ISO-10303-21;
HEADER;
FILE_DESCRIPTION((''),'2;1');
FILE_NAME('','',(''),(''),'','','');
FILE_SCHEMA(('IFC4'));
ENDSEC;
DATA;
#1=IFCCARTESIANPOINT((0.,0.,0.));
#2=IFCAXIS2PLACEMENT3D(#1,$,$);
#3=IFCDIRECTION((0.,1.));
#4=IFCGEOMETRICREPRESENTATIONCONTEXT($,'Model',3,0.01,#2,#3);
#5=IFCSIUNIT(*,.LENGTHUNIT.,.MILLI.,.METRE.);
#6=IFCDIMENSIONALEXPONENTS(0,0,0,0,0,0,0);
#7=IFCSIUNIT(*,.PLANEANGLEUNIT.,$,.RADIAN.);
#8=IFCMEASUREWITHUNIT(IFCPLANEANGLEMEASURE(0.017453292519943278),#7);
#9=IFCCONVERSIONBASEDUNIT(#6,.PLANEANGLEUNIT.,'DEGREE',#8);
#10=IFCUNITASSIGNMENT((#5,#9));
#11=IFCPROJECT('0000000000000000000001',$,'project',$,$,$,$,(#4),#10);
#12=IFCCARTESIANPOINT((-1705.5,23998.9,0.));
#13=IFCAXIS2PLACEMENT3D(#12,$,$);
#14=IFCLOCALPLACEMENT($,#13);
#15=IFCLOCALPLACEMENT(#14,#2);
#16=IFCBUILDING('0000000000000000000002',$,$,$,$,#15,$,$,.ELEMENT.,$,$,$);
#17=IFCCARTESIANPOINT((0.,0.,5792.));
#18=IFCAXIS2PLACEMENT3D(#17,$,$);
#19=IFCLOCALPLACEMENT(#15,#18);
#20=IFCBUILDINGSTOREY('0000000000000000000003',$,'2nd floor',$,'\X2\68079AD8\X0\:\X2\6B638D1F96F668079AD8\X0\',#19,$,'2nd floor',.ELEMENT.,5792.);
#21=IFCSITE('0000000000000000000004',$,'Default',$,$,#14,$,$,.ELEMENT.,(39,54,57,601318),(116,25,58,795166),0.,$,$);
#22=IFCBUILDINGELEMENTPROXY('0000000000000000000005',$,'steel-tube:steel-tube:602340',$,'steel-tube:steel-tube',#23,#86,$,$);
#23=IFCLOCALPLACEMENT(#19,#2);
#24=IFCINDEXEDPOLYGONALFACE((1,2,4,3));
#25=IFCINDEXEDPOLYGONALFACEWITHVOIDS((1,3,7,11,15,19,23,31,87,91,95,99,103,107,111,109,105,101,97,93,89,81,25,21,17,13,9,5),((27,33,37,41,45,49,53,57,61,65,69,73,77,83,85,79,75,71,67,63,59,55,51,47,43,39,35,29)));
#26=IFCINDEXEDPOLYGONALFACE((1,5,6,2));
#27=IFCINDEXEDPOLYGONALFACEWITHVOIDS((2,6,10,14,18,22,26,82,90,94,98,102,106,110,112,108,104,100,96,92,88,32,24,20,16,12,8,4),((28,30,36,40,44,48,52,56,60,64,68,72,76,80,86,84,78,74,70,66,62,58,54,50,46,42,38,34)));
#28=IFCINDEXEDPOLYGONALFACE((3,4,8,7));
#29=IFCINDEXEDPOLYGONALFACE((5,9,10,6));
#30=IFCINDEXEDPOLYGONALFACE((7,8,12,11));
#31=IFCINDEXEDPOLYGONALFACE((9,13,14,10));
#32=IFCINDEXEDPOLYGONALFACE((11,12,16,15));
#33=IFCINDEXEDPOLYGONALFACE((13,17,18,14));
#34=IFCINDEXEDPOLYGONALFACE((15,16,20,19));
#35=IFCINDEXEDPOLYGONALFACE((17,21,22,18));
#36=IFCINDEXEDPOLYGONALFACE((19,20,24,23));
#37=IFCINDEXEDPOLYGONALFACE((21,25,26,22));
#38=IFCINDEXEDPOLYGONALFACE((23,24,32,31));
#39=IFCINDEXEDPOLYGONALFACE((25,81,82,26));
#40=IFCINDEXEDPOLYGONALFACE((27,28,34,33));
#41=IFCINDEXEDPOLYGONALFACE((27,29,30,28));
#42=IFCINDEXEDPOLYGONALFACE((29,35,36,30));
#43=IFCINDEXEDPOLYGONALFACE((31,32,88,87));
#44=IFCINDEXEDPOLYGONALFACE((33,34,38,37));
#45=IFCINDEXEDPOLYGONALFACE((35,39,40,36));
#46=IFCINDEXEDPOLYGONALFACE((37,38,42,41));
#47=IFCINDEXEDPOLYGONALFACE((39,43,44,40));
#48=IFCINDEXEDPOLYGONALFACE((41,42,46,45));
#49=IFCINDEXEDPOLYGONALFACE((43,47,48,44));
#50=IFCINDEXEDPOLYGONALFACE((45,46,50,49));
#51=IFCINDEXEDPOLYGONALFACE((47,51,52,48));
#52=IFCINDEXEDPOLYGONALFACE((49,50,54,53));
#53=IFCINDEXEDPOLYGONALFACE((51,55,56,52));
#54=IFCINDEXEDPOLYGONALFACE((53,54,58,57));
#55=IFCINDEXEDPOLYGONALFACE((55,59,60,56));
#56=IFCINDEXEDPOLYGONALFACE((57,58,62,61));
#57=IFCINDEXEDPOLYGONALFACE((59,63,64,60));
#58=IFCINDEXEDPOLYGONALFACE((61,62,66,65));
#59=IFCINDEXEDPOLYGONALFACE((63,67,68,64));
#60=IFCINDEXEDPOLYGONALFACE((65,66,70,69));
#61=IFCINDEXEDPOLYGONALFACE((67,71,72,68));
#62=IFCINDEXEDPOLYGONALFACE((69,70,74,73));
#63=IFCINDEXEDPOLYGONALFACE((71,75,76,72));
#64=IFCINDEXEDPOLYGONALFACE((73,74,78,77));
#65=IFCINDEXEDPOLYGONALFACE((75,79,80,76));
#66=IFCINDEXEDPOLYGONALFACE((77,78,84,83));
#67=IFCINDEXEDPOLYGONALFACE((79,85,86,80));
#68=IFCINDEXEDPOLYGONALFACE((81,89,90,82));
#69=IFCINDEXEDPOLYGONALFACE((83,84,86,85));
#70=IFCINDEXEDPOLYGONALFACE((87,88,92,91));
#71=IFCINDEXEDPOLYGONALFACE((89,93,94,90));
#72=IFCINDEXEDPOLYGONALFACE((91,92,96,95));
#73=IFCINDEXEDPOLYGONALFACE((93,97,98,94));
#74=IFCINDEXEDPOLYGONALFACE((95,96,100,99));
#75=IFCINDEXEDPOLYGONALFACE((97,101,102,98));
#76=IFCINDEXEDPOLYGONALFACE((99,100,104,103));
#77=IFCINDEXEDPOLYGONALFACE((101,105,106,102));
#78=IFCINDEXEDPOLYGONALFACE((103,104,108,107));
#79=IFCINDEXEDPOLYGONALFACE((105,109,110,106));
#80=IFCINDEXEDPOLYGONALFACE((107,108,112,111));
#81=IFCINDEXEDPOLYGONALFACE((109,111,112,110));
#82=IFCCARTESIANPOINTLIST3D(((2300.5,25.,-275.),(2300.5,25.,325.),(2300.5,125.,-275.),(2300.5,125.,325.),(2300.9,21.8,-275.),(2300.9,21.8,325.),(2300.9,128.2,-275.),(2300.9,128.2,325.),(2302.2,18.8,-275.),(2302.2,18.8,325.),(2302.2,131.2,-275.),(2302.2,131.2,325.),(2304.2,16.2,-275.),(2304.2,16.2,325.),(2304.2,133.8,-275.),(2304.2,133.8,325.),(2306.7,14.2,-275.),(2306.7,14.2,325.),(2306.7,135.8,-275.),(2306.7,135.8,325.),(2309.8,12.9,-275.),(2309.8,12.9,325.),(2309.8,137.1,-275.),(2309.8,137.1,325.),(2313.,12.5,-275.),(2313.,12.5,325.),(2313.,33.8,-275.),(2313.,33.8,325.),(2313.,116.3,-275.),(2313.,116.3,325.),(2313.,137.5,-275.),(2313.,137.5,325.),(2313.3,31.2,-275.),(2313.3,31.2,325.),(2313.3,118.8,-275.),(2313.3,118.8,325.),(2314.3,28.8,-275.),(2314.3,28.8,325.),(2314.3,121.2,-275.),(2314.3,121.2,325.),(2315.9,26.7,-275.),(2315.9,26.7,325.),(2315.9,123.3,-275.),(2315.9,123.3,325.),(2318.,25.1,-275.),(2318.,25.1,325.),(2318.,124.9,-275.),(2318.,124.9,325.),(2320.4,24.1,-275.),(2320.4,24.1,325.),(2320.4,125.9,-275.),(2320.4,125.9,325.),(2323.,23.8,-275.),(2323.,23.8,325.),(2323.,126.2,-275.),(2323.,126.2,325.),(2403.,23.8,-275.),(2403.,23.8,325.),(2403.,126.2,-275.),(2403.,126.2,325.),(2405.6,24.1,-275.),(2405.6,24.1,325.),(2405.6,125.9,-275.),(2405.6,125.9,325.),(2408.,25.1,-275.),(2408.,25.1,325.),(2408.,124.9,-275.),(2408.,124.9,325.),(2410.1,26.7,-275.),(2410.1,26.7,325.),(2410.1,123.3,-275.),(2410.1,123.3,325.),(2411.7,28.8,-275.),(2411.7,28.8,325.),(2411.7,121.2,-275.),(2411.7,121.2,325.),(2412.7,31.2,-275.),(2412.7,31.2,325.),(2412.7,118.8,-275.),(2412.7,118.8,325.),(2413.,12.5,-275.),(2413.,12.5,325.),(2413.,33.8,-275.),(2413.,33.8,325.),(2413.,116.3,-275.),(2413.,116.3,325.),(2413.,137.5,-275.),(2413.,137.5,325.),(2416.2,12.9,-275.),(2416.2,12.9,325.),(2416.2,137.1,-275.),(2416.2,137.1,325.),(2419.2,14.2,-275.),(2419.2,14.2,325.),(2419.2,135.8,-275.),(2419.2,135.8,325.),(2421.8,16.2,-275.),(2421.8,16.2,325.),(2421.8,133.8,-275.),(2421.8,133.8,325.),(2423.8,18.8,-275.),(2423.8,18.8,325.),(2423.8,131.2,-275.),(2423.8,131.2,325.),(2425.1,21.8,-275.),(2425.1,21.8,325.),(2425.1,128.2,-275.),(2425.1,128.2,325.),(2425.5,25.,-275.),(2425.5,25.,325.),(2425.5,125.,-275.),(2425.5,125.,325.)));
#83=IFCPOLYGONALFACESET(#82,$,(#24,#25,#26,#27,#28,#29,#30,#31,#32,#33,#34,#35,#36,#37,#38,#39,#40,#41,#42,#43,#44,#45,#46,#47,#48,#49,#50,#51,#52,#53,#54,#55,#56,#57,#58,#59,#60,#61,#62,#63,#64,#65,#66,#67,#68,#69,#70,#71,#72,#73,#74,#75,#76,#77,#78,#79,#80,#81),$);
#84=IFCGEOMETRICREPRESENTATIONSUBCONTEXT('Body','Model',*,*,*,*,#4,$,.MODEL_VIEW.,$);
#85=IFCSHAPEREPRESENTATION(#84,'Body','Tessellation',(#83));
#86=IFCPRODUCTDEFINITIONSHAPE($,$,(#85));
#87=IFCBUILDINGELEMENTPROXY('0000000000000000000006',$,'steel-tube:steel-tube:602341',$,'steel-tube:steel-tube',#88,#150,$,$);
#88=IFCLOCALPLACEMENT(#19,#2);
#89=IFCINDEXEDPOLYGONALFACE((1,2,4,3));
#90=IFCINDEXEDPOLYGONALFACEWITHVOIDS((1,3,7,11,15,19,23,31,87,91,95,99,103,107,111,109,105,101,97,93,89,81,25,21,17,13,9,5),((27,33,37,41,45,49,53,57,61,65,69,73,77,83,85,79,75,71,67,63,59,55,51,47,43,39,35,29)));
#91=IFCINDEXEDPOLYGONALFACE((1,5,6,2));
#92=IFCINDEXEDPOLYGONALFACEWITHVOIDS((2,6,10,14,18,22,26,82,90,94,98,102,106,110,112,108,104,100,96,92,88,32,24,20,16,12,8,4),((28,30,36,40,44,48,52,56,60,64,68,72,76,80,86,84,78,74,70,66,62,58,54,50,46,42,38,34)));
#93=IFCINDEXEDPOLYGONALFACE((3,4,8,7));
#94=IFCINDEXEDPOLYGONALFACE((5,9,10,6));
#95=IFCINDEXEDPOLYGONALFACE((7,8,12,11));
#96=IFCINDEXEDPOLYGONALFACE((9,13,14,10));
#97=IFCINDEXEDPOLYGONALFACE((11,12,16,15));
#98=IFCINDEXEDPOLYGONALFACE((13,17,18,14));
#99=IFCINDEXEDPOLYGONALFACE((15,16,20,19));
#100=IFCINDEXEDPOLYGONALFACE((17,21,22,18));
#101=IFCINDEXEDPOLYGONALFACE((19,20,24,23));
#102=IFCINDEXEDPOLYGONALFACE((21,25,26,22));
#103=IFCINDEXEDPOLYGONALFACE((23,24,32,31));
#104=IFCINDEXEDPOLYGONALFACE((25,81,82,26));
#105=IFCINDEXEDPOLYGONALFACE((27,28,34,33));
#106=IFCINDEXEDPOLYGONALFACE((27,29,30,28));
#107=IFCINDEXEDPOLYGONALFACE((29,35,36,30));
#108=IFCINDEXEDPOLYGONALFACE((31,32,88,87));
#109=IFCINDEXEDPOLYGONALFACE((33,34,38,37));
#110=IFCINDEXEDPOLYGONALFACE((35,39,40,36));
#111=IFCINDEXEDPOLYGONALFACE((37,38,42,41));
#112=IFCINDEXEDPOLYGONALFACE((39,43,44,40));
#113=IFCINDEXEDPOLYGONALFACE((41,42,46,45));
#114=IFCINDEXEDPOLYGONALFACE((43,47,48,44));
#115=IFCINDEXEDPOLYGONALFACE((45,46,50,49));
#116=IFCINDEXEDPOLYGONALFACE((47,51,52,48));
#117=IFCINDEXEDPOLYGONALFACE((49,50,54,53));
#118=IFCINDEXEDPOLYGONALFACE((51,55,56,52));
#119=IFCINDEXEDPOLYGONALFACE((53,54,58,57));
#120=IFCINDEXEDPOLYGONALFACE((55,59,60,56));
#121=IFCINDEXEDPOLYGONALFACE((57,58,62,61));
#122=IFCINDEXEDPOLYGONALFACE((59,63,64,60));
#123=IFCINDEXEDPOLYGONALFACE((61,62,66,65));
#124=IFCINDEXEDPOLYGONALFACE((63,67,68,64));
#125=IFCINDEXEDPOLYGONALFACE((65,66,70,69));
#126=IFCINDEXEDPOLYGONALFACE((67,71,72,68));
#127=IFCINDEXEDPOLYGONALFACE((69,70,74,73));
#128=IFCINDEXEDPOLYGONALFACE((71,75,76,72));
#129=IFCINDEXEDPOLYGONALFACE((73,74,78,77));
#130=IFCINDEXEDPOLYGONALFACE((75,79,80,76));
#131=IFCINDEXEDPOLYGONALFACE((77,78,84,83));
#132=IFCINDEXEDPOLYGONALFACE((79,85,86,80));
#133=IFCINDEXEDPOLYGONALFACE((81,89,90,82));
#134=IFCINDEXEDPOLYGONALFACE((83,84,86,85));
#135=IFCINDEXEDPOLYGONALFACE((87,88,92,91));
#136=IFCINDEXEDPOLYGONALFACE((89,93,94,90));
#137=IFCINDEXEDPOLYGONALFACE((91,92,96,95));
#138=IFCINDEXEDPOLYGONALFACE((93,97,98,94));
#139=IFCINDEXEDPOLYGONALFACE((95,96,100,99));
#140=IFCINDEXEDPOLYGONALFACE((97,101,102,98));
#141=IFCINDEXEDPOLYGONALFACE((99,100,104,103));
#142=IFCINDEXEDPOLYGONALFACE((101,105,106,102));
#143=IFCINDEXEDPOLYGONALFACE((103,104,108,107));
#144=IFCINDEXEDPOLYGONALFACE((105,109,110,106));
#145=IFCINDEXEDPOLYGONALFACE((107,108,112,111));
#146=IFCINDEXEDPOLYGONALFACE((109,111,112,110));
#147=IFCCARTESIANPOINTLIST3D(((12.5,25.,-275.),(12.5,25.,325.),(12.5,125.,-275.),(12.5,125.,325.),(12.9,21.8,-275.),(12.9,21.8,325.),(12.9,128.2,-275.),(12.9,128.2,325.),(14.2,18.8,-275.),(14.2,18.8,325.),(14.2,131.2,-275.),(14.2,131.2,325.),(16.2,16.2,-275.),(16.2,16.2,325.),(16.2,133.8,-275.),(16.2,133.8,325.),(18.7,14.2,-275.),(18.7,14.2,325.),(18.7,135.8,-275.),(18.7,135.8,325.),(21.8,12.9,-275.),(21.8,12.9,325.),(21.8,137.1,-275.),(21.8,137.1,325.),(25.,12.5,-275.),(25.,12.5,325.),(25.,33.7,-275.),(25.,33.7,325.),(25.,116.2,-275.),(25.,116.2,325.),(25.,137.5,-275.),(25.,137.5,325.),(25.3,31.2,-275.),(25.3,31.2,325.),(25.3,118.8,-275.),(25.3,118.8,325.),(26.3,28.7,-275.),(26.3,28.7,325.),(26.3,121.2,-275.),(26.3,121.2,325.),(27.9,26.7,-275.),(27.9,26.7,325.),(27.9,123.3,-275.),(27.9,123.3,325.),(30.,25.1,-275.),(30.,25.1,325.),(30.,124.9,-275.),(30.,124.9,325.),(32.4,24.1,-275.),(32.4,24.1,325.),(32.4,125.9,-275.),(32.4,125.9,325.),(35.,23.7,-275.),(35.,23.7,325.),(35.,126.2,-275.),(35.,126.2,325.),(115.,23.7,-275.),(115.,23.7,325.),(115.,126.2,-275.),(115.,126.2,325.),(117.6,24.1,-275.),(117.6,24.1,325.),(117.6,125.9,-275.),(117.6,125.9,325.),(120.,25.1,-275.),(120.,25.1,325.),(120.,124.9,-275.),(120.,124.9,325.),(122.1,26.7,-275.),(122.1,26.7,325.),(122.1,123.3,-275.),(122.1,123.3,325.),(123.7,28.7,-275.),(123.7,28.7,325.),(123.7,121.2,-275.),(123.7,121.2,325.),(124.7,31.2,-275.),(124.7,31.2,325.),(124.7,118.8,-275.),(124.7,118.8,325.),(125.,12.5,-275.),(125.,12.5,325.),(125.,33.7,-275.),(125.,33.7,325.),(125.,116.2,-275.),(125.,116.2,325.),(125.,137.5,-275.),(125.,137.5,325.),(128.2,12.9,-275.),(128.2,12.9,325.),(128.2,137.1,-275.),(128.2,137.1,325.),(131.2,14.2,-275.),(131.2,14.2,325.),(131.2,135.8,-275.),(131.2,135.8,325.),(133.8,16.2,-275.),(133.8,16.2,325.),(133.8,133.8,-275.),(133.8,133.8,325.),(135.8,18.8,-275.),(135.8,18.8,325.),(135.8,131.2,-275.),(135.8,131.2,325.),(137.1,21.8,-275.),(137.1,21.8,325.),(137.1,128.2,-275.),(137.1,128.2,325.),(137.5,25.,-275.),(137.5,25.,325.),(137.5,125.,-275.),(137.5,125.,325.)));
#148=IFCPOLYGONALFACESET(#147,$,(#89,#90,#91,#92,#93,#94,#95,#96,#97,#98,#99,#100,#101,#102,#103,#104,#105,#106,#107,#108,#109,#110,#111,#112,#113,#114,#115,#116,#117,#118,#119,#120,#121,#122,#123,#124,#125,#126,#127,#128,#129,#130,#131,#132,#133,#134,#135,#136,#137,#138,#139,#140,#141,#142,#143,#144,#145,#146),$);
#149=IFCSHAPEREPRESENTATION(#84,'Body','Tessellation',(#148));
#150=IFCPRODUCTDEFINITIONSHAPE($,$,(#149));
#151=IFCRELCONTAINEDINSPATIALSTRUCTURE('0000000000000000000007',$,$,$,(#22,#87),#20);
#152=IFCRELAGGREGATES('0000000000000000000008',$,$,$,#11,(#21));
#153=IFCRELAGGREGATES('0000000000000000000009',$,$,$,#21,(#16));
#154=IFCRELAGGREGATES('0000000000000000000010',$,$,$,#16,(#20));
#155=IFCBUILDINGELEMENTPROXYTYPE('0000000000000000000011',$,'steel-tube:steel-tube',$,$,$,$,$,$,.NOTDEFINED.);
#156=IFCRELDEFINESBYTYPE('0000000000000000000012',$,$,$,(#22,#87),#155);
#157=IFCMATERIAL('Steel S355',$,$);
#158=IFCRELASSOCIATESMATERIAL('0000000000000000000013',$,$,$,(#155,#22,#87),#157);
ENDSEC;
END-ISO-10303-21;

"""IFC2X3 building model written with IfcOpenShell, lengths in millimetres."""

from ifc_helpers import new_model, entity, si_unit, converted_unit, direction, frame, frame_2d, origin, place, context, subcontext, project, spatial, polyline, circle_curve, parameter, trimmed, segment, composite_curve, outline, extrude, source, transform, mapped, material, type_object, type_shapes, element, save


model = new_model("IFC2X3")

# Units and contexts
model_context = context("Model", 3, precision=0.01, world=origin(), true_north=direction((0.0, 1.0)))
body_context = subcontext(model_context, "Body", "Model", "MODEL_VIEW")
ifc_project = project(units=[si_unit("LENGTHUNIT", "METRE", prefix="MILLI"), converted_unit("PLANEANGLEUNIT", "DEGREE", entity("IfcPlaneAngleMeasure", 0.017453292519943278), si_unit("PLANEANGLEUNIT", "RADIAN"), dimensions=[0, 0, 0, 0, 0, 0, 0])], contexts=[model_context])

# Site, building, storey
site_placement = place(None, frame((-1705.5, 23998.9, 0.0)))
site = spatial("IfcSite", under=ifc_project, at=site_placement, Name="Default", CompositionType="ELEMENT", RefLatitude=(39, 54, 57, 601318), RefLongitude=(116, 25, 58, 795166), RefElevation=0.0)
building_placement = place(site_placement, origin())
building = spatial("IfcBuilding", under=site, at=building_placement, CompositionType="ELEMENT")
storey_placement = place(building_placement, frame((0.0, 0.0, 5792.0)))
storey = spatial("IfcBuildingStorey", under=building, at=storey_placement, Name="2nd floor", ObjectType="标高:正负零标高", LongName="2nd floor", CompositionType="ELEMENT", Elevation=5792.0)

# Shared definitions
ifc_material_1 = material(Name="Steel S355")

# Building element proxies
building_element_proxy_type_1 = type_object("IfcBuildingElementProxyType", Name="steel-tube:steel-tube", PredefinedType="NOTDEFINED", material=ifc_material_1)
shared_shape_1 = source(origin(), body_context, "Body", "SweptSolid", [
    extrude(outline(composite_curve([segment(trimmed(circle_curve(frame_2d((50.0, -50.0), x_axis=(1.0, 0.0)), 12.5), [parameter(270.0)], [parameter(0.0)], True, "PARAMETER"), True, "CONTINUOUS"), segment(polyline([(62.5, -50.0), (62.5, 50.0)]), True, "CONTINUOUS"), segment(trimmed(circle_curve(frame_2d((50.0, 50.0), x_axis=(1.0, 0.0)), 12.5), [parameter(0.0)], [parameter(90.0)], True, "PARAMETER"), True, "CONTINUOUS"), segment(polyline([(50.0, 62.5), (-50.0, 62.5)]), True, "CONTINUOUS"), segment(trimmed(circle_curve(frame_2d((-50.0, 50.0), x_axis=(1.0, 0.0)), 12.5), [parameter(90.0)], [parameter(180.0)], True, "PARAMETER"), True, "CONTINUOUS"), segment(polyline([(-62.5, 50.0), (-62.5, -50.0)]), True, "CONTINUOUS"), segment(trimmed(circle_curve(frame_2d((-50.0, -50.0), x_axis=(1.0, 0.0)), 12.5), [parameter(180.0)], [parameter(270.0)], True, "PARAMETER"), True, "CONTINUOUS"), segment(polyline([(-50.0, -62.5), (50.0, -62.5)]), True, "CONTINUOUS")], self_intersect=False), holes=[composite_curve([segment(trimmed(circle_curve(frame_2d((-41.2, 40.0), x_axis=(1.0, 0.0)), 10.0), [parameter(90.0)], [parameter(180.0)], True, "PARAMETER"), False, "CONTINUOUS"), segment(polyline([(-41.3, 50.0), (41.2, 50.0)]), True, "CONTINUOUS"), segment(trimmed(circle_curve(frame_2d((41.2, 40.0), x_axis=(1.0, 0.0)), 10.0), [parameter(0.0)], [parameter(90.0)], True, "PARAMETER"), False, "CONTINUOUS"), segment(polyline([(51.2, 40.0), (51.2, -40.0)]), True, "CONTINUOUS"), segment(trimmed(circle_curve(frame_2d((41.2, -40.0), x_axis=(1.0, 0.0)), 10.0), [parameter(270.0)], [parameter(360.0)], True, "PARAMETER"), False, "CONTINUOUS"), segment(polyline([(41.2, -50.0), (-41.3, -50.0)]), True, "CONTINUOUS"), segment(trimmed(circle_curve(frame_2d((-41.3, -40.0), x_axis=(1.0, 0.0)), 10.0), [parameter(180.0)], [parameter(270.0)], True, "PARAMETER"), False, "CONTINUOUS"), segment(polyline([(-51.3, -40.0), (-51.3, 40.0)]), True, "CONTINUOUS")], self_intersect=False)]), frame((62.5, 62.5, -175.0)), (0.0, 0.0, 1.0), 600.0),
])
type_shapes(building_element_proxy_type_1, [shared_shape_1])
for number, where, z_axis, x_axis, name in (
    (1, (2300.5, 137.5, -100.0), (0.0, 0.0, 1.0), (0.0, -1.0, 0.0), "steel-tube:steel-tube:602340"),
    (2, (12.5, 137.5, -100.0), (0.0, 0.0, 1.0), (0.0, -1.0, 0.0), "steel-tube:steel-tube:602341"),
):
    element("IfcBuildingElementProxy", number, at=place(storey_placement, frame(where, z_axis=z_axis, x_axis=x_axis)), inside=storey, type_object=building_element_proxy_type_1, material=ifc_material_1, Name=name, ObjectType="steel-tube:steel-tube", context=body_context, shape_type="MappedRepresentation", body=[
        mapped(shared_shape_1, transform((0.0, 0.0, 0.0), scale=1.0)),
    ])

save(model, "model.ifc")
